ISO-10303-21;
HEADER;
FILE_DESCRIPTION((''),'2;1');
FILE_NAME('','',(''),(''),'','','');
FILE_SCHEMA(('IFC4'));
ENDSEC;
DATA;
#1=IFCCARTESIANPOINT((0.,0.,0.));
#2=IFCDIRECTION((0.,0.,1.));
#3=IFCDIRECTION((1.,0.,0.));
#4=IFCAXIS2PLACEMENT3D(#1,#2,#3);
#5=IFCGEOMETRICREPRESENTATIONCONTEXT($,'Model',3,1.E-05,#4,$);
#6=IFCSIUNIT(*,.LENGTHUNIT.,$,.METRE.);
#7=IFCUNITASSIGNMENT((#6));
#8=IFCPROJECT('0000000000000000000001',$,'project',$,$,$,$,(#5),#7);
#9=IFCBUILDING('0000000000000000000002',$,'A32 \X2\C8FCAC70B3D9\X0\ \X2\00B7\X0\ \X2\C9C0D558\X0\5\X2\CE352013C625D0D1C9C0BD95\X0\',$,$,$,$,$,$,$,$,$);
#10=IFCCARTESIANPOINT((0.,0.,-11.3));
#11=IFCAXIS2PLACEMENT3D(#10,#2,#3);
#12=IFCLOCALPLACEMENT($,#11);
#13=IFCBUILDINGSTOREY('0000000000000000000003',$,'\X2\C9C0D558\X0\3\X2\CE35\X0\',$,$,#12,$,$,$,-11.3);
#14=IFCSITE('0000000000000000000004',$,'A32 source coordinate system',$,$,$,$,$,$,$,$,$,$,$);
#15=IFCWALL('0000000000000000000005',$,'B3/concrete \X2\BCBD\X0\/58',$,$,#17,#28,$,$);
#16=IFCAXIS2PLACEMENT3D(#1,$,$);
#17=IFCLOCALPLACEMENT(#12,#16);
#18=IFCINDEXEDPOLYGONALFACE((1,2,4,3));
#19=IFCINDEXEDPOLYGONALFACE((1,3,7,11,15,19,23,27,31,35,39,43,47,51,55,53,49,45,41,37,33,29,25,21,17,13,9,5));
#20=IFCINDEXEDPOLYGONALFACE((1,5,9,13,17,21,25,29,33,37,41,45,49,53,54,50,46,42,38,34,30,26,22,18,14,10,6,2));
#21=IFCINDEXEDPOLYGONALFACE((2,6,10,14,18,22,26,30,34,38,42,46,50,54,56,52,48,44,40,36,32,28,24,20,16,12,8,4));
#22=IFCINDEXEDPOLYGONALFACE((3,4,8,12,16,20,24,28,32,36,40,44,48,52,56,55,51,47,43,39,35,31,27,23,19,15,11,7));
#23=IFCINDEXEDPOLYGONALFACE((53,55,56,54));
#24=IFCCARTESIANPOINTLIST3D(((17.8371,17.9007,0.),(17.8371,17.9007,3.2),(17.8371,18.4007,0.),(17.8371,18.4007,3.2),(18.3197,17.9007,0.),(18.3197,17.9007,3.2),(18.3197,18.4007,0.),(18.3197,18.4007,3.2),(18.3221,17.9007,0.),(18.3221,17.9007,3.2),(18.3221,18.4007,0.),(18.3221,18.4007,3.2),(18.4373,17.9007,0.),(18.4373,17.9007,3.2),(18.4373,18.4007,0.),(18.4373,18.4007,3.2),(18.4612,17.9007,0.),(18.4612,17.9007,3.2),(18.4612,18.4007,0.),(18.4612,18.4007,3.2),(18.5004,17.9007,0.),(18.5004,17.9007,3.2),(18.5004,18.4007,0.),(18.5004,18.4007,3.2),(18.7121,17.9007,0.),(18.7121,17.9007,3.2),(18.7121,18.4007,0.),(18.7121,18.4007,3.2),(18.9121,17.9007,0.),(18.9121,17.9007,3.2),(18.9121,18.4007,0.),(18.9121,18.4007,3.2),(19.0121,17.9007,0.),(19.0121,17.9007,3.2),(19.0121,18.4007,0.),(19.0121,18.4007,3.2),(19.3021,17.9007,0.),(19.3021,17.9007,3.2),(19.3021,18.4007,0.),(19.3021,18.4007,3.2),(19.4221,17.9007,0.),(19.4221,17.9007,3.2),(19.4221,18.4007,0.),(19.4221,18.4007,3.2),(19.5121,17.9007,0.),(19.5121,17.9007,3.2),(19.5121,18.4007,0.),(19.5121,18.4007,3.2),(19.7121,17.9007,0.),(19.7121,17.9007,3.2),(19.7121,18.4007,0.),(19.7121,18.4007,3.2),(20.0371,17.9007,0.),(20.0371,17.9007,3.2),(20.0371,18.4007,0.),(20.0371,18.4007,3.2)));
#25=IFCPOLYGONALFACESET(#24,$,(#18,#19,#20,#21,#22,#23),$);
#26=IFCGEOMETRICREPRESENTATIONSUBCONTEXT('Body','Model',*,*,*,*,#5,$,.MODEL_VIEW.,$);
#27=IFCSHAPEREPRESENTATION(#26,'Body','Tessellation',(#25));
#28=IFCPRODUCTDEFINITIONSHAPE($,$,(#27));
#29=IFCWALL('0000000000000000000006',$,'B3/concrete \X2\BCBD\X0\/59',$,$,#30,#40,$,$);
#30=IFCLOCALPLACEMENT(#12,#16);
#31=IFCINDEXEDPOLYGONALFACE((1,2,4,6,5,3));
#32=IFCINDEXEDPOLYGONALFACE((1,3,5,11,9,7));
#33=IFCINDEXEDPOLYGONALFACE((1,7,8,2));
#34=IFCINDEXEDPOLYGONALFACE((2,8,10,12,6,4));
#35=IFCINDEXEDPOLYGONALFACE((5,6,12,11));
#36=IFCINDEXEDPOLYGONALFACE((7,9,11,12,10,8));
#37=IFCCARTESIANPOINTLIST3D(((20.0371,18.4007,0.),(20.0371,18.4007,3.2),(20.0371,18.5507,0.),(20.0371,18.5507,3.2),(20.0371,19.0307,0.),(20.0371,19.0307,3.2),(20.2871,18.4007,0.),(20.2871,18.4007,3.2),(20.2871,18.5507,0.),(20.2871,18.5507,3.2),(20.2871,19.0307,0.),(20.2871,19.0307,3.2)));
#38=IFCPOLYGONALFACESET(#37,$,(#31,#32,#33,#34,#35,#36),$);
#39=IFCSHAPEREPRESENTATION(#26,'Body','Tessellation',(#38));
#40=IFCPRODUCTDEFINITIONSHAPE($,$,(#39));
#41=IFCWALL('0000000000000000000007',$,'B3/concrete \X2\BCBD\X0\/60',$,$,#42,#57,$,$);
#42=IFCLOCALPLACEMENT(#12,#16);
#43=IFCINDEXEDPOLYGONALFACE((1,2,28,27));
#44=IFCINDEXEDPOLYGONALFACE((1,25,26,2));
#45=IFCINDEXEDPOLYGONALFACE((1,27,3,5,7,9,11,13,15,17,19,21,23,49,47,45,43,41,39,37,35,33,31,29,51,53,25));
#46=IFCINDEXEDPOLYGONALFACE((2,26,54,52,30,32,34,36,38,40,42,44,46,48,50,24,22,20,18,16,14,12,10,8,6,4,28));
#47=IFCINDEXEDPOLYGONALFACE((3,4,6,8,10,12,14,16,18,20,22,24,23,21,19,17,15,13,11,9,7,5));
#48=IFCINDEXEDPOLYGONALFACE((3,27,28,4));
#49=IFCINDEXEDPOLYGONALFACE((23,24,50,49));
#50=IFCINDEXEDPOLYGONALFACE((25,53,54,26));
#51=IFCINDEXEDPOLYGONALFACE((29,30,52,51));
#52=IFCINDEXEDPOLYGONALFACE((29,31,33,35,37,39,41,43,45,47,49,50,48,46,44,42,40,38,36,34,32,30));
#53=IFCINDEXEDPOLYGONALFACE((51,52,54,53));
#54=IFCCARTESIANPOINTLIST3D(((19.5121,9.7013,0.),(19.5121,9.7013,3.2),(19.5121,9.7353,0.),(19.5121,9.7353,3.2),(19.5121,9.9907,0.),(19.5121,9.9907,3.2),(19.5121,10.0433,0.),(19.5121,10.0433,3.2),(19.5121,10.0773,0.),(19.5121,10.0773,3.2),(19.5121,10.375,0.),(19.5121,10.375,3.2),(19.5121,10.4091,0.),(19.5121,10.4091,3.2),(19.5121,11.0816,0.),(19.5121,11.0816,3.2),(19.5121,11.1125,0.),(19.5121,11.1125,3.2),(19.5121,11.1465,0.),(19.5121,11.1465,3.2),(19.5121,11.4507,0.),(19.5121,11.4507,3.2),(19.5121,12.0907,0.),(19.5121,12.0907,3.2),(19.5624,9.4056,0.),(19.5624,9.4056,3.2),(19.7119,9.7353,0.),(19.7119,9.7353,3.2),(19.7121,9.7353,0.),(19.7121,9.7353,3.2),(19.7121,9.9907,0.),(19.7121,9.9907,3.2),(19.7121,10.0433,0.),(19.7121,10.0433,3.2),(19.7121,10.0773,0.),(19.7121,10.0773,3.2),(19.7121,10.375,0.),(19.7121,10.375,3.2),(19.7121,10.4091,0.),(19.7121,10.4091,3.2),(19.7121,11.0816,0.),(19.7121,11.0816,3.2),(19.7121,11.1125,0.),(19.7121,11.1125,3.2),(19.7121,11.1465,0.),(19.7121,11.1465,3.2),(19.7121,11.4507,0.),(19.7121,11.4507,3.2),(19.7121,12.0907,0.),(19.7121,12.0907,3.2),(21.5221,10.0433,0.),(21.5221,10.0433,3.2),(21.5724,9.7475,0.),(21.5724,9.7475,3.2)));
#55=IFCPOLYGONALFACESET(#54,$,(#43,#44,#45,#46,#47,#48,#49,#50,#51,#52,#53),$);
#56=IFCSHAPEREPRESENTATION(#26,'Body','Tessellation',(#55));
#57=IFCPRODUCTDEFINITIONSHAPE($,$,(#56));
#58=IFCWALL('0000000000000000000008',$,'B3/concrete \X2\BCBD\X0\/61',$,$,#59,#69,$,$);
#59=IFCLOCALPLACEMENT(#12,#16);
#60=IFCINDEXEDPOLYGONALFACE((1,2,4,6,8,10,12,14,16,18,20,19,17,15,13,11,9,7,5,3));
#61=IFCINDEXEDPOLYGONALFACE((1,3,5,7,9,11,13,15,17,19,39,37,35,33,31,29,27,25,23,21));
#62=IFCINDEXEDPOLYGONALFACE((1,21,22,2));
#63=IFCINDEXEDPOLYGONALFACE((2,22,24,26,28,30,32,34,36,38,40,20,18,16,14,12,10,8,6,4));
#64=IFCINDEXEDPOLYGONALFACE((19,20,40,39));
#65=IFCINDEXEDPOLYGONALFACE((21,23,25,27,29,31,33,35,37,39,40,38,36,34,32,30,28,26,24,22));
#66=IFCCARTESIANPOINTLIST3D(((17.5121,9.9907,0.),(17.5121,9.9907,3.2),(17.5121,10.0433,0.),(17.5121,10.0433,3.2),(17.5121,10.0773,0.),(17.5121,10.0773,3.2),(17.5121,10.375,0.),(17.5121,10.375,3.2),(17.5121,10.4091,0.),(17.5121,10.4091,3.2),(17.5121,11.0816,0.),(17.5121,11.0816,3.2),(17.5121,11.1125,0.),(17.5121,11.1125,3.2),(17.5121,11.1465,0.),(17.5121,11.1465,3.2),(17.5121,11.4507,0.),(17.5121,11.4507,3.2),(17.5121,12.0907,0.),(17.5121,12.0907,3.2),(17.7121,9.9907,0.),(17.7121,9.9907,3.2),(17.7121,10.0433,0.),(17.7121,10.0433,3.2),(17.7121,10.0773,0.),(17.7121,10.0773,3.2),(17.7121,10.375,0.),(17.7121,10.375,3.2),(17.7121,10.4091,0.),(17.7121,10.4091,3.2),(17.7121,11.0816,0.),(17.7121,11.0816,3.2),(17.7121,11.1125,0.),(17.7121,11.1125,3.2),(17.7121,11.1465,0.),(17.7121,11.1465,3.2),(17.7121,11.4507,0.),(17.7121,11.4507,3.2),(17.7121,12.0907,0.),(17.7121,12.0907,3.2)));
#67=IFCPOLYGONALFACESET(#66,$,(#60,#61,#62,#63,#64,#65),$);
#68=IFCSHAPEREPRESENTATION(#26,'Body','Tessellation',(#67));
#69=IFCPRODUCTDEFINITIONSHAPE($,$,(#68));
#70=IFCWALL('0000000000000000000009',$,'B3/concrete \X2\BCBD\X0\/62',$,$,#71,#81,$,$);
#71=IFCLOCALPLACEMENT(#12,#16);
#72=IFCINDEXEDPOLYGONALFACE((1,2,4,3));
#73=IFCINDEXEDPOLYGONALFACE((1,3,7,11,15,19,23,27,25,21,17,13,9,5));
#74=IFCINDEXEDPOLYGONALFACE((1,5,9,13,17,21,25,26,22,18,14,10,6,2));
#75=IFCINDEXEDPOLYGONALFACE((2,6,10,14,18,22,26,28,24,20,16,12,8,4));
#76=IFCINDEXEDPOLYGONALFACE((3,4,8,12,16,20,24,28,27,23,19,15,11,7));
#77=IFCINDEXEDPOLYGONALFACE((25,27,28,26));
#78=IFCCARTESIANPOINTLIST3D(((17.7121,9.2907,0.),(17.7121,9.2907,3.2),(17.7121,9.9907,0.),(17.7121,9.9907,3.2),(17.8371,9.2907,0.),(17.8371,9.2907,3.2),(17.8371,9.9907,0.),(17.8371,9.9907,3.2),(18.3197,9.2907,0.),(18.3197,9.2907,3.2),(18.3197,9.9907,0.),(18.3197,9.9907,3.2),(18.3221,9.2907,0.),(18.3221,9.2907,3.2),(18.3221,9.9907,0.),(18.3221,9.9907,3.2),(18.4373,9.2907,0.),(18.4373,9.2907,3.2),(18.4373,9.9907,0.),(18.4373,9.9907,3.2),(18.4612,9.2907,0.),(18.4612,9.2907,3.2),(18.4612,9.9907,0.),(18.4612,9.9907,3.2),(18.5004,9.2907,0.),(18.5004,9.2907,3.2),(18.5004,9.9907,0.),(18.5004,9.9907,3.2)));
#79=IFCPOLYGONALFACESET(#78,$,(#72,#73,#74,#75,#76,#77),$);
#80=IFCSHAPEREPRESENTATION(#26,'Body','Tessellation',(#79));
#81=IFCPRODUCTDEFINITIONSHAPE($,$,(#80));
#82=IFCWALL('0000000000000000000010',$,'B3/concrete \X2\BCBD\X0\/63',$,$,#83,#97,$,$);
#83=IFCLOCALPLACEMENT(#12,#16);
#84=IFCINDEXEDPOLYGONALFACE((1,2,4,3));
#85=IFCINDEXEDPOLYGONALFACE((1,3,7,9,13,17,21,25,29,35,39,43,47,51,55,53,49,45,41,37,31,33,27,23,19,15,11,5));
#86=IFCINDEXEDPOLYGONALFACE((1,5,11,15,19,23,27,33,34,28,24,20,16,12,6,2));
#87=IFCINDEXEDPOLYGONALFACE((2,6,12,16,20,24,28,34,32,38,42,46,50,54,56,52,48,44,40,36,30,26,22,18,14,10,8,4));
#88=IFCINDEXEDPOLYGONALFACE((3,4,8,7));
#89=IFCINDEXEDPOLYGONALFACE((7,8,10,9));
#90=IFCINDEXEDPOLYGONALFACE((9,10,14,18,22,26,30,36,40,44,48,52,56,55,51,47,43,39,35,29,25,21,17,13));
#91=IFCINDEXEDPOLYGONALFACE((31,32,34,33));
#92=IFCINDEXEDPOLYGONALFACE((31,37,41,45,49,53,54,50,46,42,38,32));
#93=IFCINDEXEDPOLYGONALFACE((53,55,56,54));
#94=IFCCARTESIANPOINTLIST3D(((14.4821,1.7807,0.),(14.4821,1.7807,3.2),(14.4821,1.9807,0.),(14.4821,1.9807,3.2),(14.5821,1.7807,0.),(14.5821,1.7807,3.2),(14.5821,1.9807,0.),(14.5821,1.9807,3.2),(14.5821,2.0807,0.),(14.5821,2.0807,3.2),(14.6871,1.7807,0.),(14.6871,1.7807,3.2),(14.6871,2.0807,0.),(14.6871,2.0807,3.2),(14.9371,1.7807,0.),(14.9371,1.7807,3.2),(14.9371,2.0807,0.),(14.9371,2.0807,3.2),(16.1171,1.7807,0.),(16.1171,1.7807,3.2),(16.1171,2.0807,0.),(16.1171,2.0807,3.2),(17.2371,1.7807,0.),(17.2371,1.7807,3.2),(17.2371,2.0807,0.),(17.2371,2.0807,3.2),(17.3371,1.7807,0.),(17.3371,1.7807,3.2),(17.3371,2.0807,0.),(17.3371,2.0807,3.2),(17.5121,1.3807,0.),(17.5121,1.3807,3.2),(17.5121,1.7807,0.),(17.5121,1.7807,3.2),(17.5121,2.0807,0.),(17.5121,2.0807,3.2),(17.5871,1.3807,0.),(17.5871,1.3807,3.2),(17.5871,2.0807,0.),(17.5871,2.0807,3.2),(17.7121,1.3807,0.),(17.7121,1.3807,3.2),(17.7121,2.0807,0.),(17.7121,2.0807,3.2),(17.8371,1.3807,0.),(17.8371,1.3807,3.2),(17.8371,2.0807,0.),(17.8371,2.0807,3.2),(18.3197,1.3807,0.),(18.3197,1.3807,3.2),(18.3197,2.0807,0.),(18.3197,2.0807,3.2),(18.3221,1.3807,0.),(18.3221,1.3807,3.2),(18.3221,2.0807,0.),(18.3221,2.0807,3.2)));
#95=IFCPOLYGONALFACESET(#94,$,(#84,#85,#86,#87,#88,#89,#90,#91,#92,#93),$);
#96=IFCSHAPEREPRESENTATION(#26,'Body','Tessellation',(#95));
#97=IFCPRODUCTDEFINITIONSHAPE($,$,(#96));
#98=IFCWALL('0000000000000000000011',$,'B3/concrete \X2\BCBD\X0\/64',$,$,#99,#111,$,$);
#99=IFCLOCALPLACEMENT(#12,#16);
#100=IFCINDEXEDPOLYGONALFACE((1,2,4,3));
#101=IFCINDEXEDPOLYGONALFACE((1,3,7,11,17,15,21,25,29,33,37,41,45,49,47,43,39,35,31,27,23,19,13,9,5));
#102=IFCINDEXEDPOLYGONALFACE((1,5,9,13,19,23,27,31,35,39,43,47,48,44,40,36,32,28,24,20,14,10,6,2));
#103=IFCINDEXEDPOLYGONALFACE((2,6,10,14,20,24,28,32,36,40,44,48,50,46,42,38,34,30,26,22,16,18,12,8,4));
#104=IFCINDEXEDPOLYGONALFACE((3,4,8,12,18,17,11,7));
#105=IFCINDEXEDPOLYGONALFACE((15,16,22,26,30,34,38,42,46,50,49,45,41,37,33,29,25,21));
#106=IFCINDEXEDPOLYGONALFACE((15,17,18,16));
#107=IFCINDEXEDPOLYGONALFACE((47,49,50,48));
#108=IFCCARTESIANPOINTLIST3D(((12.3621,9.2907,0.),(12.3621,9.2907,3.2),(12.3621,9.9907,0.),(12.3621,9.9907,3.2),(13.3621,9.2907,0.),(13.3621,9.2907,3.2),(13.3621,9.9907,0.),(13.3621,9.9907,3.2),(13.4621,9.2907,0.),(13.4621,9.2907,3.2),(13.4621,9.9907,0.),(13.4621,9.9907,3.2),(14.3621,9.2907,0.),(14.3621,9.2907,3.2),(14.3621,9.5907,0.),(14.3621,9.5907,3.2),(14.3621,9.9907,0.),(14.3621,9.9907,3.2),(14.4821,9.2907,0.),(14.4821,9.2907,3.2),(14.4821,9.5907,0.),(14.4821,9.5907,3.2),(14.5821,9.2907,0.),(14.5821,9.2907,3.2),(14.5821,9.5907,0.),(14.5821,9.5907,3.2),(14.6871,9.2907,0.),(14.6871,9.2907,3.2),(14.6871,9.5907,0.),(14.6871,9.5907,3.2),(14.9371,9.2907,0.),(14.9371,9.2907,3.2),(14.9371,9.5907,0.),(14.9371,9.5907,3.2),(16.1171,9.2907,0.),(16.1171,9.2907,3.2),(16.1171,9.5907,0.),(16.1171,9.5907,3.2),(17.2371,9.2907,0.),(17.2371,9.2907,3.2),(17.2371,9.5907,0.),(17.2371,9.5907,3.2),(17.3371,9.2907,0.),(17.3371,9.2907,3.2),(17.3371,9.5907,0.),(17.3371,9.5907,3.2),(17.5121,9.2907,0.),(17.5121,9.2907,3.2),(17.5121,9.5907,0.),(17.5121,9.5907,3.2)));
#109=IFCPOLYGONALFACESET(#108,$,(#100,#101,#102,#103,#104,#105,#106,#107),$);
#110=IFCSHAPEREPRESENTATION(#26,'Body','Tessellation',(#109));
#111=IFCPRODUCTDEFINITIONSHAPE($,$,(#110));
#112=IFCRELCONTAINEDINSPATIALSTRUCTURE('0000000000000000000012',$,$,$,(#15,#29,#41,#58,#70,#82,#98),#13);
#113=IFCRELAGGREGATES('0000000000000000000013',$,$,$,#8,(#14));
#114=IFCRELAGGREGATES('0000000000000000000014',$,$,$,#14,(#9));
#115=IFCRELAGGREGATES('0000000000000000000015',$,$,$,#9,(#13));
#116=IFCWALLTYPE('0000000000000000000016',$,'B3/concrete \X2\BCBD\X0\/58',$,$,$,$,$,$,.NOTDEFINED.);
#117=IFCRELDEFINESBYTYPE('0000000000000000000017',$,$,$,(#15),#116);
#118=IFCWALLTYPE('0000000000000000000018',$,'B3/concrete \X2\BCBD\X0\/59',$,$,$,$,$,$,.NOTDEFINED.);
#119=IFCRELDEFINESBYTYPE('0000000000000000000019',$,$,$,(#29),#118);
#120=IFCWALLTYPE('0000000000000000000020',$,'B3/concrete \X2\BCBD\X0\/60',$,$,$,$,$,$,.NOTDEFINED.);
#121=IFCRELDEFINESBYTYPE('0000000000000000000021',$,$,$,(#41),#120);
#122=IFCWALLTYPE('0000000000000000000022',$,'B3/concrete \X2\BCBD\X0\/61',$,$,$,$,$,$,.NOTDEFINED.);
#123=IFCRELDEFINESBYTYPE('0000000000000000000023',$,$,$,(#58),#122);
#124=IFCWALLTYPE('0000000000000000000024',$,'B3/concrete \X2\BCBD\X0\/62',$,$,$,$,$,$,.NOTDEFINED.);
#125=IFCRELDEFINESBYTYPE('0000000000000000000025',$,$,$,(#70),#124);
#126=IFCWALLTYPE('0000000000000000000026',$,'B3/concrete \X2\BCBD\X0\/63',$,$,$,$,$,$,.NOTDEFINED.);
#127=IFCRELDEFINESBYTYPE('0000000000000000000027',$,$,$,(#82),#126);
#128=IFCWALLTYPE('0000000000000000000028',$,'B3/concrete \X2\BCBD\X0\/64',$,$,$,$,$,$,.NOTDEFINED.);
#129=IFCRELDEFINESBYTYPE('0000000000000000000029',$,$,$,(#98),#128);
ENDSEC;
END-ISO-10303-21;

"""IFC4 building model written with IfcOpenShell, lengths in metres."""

from ifc_helpers import new_model, si_unit, frame, origin, origin_with_axes, place, context, subcontext, project, spatial, polyline, outline, extrude, source, transform, mapped, type_object, type_shapes, element, save


model = new_model("IFC4")

# Units and contexts
model_context = context("Model", 3, precision=1e-05, world=origin_with_axes())
body_context = subcontext(model_context, "Body", "Model", "MODEL_VIEW")
ifc_project = project(units=[si_unit("LENGTHUNIT", "METRE")], contexts=[model_context])

# Site, building, storey
site = spatial("IfcSite", under=ifc_project, Name="A32 source coordinate system")
building = spatial("IfcBuilding", under=site, Name="A32 주거동 · 지하5층–옥탑지붕")
storey_placement = place(None, frame((0.0, 0.0, -11.3), z_axis=(0.0, 0.0, 1.0), x_axis=(1.0, 0.0, 0.0)))
storey = spatial("IfcBuildingStorey", under=building, at=storey_placement, Name="지하3층", Elevation=-11.3)

# Walls
wall_type_1 = type_object("IfcWallType", Name="B3/concrete 벽/58", PredefinedType="NOTDEFINED")
shared_shape_1 = source(origin(), body_context, "Body", "SweptSolid", [
    extrude(outline(polyline([(18.3221, 18.4007), (18.4373, 18.4007), (18.4612, 18.4007), (18.5004, 18.4007), (18.7121, 18.4007), (18.9121, 18.4007), (19.0121, 18.4007), (19.3021, 18.4007), (19.4221, 18.4007), (19.5121, 18.4007), (19.7121, 18.4007), (20.0371, 18.4007), (20.0371, 17.9007), (19.7121, 17.9007), (19.5121, 17.9007), (19.4221, 17.9007), (19.3021, 17.9007), (19.0121, 17.9007), (18.9121, 17.9007), (18.7121, 17.9007), (18.5004, 17.9007), (18.4612, 17.9007), (18.4373, 17.9007), (18.3221, 17.9007), (18.3197, 17.9007), (17.8371, 17.9007), (17.8371, 18.4007), (18.3197, 18.4007), (18.3221, 18.4007)])), origin(), (0.0, 0.0, 1.0), 3.2),
])
type_shapes(wall_type_1, [shared_shape_1])
wall_1_placement = place(storey_placement, origin_with_axes())
element("IfcWall", 1, at=wall_1_placement, inside=storey, type_object=wall_type_1, Name="B3/concrete 벽/58", context=body_context, shape_type="MappedRepresentation", body=[
    mapped(shared_shape_1, transform((0.0, 0.0, 0.0), scale=1.0)),
])
wall_type_2 = type_object("IfcWallType", Name="B3/concrete 벽/59", PredefinedType="NOTDEFINED")
shared_shape_2 = source(origin(), body_context, "Body", "SweptSolid", [
    extrude(outline(polyline([(20.2871, 19.0307), (20.2871, 18.5507), (20.2871, 18.4007), (20.0371, 18.4007), (20.0371, 18.5507), (20.0371, 19.0307), (20.2871, 19.0307)])), origin(), (0.0, 0.0, 1.0), 3.2),
])
type_shapes(wall_type_2, [shared_shape_2])
wall_2_placement = place(storey_placement, origin_with_axes())
element("IfcWall", 2, at=wall_2_placement, inside=storey, type_object=wall_type_2, Name="B3/concrete 벽/59", context=body_context, shape_type="MappedRepresentation", body=[
    mapped(shared_shape_2, transform((0.0, 0.0, 0.0), scale=1.0)),
])
wall_type_3 = type_object("IfcWallType", Name="B3/concrete 벽/60", PredefinedType="NOTDEFINED")
shared_shape_3 = source(origin(), body_context, "Body", "SweptSolid", [
    extrude(outline(polyline([(19.5121, 12.0907), (19.7121, 12.0907), (19.7121, 11.4507), (19.7121, 11.1465), (19.7121, 11.1125), (19.7121, 11.0816), (19.7121, 10.4091), (19.7121, 10.375), (19.7121, 10.0773), (19.7121, 10.0433), (19.7121, 9.9907), (19.7121, 9.7353), (21.5221, 10.0433), (21.5724, 9.7475), (19.5624, 9.4056), (19.5121, 9.7013), (19.7119, 9.7353), (19.5121, 9.7353), (19.5121, 9.9907), (19.5121, 10.0433), (19.5121, 10.0773), (19.5121, 10.375), (19.5121, 10.4091), (19.5121, 11.0816), (19.5121, 11.1125), (19.5121, 11.1465), (19.5121, 11.4507), (19.5121, 12.0907)])), origin(), (0.0, 0.0, 1.0), 3.2),
])
type_shapes(wall_type_3, [shared_shape_3])
wall_3_placement = place(storey_placement, origin_with_axes())
element("IfcWall", 3, at=wall_3_placement, inside=storey, type_object=wall_type_3, Name="B3/concrete 벽/60", context=body_context, shape_type="MappedRepresentation", body=[
    mapped(shared_shape_3, transform((0.0, 0.0, 0.0), scale=1.0)),
])
wall_type_4 = type_object("IfcWallType", Name="B3/concrete 벽/61", PredefinedType="NOTDEFINED")
shared_shape_4 = source(origin(), body_context, "Body", "SweptSolid", [
    extrude(outline(polyline([(17.5121, 12.0907), (17.7121, 12.0907), (17.7121, 11.4507), (17.7121, 11.1465), (17.7121, 11.1125), (17.7121, 11.0816), (17.7121, 10.4091), (17.7121, 10.375), (17.7121, 10.0773), (17.7121, 10.0433), (17.7121, 9.9907), (17.5121, 9.9907), (17.5121, 10.0433), (17.5121, 10.0773), (17.5121, 10.375), (17.5121, 10.4091), (17.5121, 11.0816), (17.5121, 11.1125), (17.5121, 11.1465), (17.5121, 11.4507), (17.5121, 12.0907)])), origin(), (0.0, 0.0, 1.0), 3.2),
])
type_shapes(wall_type_4, [shared_shape_4])
wall_4_placement = place(storey_placement, origin_with_axes())
element("IfcWall", 4, at=wall_4_placement, inside=storey, type_object=wall_type_4, Name="B3/concrete 벽/61", context=body_context, shape_type="MappedRepresentation", body=[
    mapped(shared_shape_4, transform((0.0, 0.0, 0.0), scale=1.0)),
])
wall_type_5 = type_object("IfcWallType", Name="B3/concrete 벽/62", PredefinedType="NOTDEFINED")
shared_shape_5 = source(origin(), body_context, "Body", "SweptSolid", [
    extrude(outline(polyline([(18.3221, 9.9907), (18.4373, 9.9907), (18.4612, 9.9907), (18.5004, 9.9907), (18.5004, 9.2907), (18.4612, 9.2907), (18.4373, 9.2907), (18.3221, 9.2907), (18.3197, 9.2907), (17.8371, 9.2907), (17.7121, 9.2907), (17.7121, 9.9907), (17.8371, 9.9907), (18.3197, 9.9907), (18.3221, 9.9907)])), origin(), (0.0, 0.0, 1.0), 3.2),
])
type_shapes(wall_type_5, [shared_shape_5])
wall_5_placement = place(storey_placement, origin_with_axes())
element("IfcWall", 5, at=wall_5_placement, inside=storey, type_object=wall_type_5, Name="B3/concrete 벽/62", context=body_context, shape_type="MappedRepresentation", body=[
    mapped(shared_shape_5, transform((0.0, 0.0, 0.0), scale=1.0)),
])
wall_type_6 = type_object("IfcWallType", Name="B3/concrete 벽/63", PredefinedType="NOTDEFINED")
shared_shape_6 = source(origin(), body_context, "Body", "SweptSolid", [
    extrude(outline(polyline([(14.9371, 2.0807), (16.1171, 2.0807), (17.2371, 2.0807), (17.3371, 2.0807), (17.5121, 2.0807), (17.5871, 2.0807), (17.7121, 2.0807), (17.8371, 2.0807), (18.3197, 2.0807), (18.3221, 2.0807), (18.3221, 1.3807), (18.3197, 1.3807), (17.8371, 1.3807), (17.7121, 1.3807), (17.5871, 1.3807), (17.5121, 1.3807), (17.5121, 1.7807), (17.3371, 1.7807), (17.2371, 1.7807), (16.1171, 1.7807), (14.9371, 1.7807), (14.6871, 1.7807), (14.5821, 1.7807), (14.4821, 1.7807), (14.4821, 1.9807), (14.5821, 1.9807), (14.5821, 2.0807), (14.6871, 2.0807), (14.9371, 2.0807)])), origin(), (0.0, 0.0, 1.0), 3.2),
])
type_shapes(wall_type_6, [shared_shape_6])
wall_6_placement = place(storey_placement, origin_with_axes())
element("IfcWall", 6, at=wall_6_placement, inside=storey, type_object=wall_type_6, Name="B3/concrete 벽/63", context=body_context, shape_type="MappedRepresentation", body=[
    mapped(shared_shape_6, transform((0.0, 0.0, 0.0), scale=1.0)),
])
wall_type_7 = type_object("IfcWallType", Name="B3/concrete 벽/64", PredefinedType="NOTDEFINED")
shared_shape_7 = source(origin(), body_context, "Body", "SweptSolid", [
    extrude(outline(polyline([(13.4621, 9.9907), (14.3621, 9.9907), (14.3621, 9.5907), (14.4821, 9.5907), (14.5821, 9.5907), (14.6871, 9.5907), (14.9371, 9.5907), (16.1171, 9.5907), (17.2371, 9.5907), (17.3371, 9.5907), (17.5121, 9.5907), (17.5121, 9.2907), (17.3371, 9.2907), (17.2371, 9.2907), (16.1171, 9.2907), (14.9371, 9.2907), (14.6871, 9.2907), (14.5821, 9.2907), (14.4821, 9.2907), (14.3621, 9.2907), (13.4621, 9.2907), (13.3621, 9.2907), (12.3621, 9.2907), (12.3621, 9.9907), (13.3621, 9.9907), (13.4621, 9.9907)])), origin(), (0.0, 0.0, 1.0), 3.2),
])
type_shapes(wall_type_7, [shared_shape_7])
wall_7_placement = place(storey_placement, origin_with_axes())
element("IfcWall", 7, at=wall_7_placement, inside=storey, type_object=wall_type_7, Name="B3/concrete 벽/64", context=body_context, shape_type="MappedRepresentation", body=[
    mapped(shared_shape_7, transform((0.0, 0.0, 0.0), scale=1.0)),
])

save(model, "model.ifc")
